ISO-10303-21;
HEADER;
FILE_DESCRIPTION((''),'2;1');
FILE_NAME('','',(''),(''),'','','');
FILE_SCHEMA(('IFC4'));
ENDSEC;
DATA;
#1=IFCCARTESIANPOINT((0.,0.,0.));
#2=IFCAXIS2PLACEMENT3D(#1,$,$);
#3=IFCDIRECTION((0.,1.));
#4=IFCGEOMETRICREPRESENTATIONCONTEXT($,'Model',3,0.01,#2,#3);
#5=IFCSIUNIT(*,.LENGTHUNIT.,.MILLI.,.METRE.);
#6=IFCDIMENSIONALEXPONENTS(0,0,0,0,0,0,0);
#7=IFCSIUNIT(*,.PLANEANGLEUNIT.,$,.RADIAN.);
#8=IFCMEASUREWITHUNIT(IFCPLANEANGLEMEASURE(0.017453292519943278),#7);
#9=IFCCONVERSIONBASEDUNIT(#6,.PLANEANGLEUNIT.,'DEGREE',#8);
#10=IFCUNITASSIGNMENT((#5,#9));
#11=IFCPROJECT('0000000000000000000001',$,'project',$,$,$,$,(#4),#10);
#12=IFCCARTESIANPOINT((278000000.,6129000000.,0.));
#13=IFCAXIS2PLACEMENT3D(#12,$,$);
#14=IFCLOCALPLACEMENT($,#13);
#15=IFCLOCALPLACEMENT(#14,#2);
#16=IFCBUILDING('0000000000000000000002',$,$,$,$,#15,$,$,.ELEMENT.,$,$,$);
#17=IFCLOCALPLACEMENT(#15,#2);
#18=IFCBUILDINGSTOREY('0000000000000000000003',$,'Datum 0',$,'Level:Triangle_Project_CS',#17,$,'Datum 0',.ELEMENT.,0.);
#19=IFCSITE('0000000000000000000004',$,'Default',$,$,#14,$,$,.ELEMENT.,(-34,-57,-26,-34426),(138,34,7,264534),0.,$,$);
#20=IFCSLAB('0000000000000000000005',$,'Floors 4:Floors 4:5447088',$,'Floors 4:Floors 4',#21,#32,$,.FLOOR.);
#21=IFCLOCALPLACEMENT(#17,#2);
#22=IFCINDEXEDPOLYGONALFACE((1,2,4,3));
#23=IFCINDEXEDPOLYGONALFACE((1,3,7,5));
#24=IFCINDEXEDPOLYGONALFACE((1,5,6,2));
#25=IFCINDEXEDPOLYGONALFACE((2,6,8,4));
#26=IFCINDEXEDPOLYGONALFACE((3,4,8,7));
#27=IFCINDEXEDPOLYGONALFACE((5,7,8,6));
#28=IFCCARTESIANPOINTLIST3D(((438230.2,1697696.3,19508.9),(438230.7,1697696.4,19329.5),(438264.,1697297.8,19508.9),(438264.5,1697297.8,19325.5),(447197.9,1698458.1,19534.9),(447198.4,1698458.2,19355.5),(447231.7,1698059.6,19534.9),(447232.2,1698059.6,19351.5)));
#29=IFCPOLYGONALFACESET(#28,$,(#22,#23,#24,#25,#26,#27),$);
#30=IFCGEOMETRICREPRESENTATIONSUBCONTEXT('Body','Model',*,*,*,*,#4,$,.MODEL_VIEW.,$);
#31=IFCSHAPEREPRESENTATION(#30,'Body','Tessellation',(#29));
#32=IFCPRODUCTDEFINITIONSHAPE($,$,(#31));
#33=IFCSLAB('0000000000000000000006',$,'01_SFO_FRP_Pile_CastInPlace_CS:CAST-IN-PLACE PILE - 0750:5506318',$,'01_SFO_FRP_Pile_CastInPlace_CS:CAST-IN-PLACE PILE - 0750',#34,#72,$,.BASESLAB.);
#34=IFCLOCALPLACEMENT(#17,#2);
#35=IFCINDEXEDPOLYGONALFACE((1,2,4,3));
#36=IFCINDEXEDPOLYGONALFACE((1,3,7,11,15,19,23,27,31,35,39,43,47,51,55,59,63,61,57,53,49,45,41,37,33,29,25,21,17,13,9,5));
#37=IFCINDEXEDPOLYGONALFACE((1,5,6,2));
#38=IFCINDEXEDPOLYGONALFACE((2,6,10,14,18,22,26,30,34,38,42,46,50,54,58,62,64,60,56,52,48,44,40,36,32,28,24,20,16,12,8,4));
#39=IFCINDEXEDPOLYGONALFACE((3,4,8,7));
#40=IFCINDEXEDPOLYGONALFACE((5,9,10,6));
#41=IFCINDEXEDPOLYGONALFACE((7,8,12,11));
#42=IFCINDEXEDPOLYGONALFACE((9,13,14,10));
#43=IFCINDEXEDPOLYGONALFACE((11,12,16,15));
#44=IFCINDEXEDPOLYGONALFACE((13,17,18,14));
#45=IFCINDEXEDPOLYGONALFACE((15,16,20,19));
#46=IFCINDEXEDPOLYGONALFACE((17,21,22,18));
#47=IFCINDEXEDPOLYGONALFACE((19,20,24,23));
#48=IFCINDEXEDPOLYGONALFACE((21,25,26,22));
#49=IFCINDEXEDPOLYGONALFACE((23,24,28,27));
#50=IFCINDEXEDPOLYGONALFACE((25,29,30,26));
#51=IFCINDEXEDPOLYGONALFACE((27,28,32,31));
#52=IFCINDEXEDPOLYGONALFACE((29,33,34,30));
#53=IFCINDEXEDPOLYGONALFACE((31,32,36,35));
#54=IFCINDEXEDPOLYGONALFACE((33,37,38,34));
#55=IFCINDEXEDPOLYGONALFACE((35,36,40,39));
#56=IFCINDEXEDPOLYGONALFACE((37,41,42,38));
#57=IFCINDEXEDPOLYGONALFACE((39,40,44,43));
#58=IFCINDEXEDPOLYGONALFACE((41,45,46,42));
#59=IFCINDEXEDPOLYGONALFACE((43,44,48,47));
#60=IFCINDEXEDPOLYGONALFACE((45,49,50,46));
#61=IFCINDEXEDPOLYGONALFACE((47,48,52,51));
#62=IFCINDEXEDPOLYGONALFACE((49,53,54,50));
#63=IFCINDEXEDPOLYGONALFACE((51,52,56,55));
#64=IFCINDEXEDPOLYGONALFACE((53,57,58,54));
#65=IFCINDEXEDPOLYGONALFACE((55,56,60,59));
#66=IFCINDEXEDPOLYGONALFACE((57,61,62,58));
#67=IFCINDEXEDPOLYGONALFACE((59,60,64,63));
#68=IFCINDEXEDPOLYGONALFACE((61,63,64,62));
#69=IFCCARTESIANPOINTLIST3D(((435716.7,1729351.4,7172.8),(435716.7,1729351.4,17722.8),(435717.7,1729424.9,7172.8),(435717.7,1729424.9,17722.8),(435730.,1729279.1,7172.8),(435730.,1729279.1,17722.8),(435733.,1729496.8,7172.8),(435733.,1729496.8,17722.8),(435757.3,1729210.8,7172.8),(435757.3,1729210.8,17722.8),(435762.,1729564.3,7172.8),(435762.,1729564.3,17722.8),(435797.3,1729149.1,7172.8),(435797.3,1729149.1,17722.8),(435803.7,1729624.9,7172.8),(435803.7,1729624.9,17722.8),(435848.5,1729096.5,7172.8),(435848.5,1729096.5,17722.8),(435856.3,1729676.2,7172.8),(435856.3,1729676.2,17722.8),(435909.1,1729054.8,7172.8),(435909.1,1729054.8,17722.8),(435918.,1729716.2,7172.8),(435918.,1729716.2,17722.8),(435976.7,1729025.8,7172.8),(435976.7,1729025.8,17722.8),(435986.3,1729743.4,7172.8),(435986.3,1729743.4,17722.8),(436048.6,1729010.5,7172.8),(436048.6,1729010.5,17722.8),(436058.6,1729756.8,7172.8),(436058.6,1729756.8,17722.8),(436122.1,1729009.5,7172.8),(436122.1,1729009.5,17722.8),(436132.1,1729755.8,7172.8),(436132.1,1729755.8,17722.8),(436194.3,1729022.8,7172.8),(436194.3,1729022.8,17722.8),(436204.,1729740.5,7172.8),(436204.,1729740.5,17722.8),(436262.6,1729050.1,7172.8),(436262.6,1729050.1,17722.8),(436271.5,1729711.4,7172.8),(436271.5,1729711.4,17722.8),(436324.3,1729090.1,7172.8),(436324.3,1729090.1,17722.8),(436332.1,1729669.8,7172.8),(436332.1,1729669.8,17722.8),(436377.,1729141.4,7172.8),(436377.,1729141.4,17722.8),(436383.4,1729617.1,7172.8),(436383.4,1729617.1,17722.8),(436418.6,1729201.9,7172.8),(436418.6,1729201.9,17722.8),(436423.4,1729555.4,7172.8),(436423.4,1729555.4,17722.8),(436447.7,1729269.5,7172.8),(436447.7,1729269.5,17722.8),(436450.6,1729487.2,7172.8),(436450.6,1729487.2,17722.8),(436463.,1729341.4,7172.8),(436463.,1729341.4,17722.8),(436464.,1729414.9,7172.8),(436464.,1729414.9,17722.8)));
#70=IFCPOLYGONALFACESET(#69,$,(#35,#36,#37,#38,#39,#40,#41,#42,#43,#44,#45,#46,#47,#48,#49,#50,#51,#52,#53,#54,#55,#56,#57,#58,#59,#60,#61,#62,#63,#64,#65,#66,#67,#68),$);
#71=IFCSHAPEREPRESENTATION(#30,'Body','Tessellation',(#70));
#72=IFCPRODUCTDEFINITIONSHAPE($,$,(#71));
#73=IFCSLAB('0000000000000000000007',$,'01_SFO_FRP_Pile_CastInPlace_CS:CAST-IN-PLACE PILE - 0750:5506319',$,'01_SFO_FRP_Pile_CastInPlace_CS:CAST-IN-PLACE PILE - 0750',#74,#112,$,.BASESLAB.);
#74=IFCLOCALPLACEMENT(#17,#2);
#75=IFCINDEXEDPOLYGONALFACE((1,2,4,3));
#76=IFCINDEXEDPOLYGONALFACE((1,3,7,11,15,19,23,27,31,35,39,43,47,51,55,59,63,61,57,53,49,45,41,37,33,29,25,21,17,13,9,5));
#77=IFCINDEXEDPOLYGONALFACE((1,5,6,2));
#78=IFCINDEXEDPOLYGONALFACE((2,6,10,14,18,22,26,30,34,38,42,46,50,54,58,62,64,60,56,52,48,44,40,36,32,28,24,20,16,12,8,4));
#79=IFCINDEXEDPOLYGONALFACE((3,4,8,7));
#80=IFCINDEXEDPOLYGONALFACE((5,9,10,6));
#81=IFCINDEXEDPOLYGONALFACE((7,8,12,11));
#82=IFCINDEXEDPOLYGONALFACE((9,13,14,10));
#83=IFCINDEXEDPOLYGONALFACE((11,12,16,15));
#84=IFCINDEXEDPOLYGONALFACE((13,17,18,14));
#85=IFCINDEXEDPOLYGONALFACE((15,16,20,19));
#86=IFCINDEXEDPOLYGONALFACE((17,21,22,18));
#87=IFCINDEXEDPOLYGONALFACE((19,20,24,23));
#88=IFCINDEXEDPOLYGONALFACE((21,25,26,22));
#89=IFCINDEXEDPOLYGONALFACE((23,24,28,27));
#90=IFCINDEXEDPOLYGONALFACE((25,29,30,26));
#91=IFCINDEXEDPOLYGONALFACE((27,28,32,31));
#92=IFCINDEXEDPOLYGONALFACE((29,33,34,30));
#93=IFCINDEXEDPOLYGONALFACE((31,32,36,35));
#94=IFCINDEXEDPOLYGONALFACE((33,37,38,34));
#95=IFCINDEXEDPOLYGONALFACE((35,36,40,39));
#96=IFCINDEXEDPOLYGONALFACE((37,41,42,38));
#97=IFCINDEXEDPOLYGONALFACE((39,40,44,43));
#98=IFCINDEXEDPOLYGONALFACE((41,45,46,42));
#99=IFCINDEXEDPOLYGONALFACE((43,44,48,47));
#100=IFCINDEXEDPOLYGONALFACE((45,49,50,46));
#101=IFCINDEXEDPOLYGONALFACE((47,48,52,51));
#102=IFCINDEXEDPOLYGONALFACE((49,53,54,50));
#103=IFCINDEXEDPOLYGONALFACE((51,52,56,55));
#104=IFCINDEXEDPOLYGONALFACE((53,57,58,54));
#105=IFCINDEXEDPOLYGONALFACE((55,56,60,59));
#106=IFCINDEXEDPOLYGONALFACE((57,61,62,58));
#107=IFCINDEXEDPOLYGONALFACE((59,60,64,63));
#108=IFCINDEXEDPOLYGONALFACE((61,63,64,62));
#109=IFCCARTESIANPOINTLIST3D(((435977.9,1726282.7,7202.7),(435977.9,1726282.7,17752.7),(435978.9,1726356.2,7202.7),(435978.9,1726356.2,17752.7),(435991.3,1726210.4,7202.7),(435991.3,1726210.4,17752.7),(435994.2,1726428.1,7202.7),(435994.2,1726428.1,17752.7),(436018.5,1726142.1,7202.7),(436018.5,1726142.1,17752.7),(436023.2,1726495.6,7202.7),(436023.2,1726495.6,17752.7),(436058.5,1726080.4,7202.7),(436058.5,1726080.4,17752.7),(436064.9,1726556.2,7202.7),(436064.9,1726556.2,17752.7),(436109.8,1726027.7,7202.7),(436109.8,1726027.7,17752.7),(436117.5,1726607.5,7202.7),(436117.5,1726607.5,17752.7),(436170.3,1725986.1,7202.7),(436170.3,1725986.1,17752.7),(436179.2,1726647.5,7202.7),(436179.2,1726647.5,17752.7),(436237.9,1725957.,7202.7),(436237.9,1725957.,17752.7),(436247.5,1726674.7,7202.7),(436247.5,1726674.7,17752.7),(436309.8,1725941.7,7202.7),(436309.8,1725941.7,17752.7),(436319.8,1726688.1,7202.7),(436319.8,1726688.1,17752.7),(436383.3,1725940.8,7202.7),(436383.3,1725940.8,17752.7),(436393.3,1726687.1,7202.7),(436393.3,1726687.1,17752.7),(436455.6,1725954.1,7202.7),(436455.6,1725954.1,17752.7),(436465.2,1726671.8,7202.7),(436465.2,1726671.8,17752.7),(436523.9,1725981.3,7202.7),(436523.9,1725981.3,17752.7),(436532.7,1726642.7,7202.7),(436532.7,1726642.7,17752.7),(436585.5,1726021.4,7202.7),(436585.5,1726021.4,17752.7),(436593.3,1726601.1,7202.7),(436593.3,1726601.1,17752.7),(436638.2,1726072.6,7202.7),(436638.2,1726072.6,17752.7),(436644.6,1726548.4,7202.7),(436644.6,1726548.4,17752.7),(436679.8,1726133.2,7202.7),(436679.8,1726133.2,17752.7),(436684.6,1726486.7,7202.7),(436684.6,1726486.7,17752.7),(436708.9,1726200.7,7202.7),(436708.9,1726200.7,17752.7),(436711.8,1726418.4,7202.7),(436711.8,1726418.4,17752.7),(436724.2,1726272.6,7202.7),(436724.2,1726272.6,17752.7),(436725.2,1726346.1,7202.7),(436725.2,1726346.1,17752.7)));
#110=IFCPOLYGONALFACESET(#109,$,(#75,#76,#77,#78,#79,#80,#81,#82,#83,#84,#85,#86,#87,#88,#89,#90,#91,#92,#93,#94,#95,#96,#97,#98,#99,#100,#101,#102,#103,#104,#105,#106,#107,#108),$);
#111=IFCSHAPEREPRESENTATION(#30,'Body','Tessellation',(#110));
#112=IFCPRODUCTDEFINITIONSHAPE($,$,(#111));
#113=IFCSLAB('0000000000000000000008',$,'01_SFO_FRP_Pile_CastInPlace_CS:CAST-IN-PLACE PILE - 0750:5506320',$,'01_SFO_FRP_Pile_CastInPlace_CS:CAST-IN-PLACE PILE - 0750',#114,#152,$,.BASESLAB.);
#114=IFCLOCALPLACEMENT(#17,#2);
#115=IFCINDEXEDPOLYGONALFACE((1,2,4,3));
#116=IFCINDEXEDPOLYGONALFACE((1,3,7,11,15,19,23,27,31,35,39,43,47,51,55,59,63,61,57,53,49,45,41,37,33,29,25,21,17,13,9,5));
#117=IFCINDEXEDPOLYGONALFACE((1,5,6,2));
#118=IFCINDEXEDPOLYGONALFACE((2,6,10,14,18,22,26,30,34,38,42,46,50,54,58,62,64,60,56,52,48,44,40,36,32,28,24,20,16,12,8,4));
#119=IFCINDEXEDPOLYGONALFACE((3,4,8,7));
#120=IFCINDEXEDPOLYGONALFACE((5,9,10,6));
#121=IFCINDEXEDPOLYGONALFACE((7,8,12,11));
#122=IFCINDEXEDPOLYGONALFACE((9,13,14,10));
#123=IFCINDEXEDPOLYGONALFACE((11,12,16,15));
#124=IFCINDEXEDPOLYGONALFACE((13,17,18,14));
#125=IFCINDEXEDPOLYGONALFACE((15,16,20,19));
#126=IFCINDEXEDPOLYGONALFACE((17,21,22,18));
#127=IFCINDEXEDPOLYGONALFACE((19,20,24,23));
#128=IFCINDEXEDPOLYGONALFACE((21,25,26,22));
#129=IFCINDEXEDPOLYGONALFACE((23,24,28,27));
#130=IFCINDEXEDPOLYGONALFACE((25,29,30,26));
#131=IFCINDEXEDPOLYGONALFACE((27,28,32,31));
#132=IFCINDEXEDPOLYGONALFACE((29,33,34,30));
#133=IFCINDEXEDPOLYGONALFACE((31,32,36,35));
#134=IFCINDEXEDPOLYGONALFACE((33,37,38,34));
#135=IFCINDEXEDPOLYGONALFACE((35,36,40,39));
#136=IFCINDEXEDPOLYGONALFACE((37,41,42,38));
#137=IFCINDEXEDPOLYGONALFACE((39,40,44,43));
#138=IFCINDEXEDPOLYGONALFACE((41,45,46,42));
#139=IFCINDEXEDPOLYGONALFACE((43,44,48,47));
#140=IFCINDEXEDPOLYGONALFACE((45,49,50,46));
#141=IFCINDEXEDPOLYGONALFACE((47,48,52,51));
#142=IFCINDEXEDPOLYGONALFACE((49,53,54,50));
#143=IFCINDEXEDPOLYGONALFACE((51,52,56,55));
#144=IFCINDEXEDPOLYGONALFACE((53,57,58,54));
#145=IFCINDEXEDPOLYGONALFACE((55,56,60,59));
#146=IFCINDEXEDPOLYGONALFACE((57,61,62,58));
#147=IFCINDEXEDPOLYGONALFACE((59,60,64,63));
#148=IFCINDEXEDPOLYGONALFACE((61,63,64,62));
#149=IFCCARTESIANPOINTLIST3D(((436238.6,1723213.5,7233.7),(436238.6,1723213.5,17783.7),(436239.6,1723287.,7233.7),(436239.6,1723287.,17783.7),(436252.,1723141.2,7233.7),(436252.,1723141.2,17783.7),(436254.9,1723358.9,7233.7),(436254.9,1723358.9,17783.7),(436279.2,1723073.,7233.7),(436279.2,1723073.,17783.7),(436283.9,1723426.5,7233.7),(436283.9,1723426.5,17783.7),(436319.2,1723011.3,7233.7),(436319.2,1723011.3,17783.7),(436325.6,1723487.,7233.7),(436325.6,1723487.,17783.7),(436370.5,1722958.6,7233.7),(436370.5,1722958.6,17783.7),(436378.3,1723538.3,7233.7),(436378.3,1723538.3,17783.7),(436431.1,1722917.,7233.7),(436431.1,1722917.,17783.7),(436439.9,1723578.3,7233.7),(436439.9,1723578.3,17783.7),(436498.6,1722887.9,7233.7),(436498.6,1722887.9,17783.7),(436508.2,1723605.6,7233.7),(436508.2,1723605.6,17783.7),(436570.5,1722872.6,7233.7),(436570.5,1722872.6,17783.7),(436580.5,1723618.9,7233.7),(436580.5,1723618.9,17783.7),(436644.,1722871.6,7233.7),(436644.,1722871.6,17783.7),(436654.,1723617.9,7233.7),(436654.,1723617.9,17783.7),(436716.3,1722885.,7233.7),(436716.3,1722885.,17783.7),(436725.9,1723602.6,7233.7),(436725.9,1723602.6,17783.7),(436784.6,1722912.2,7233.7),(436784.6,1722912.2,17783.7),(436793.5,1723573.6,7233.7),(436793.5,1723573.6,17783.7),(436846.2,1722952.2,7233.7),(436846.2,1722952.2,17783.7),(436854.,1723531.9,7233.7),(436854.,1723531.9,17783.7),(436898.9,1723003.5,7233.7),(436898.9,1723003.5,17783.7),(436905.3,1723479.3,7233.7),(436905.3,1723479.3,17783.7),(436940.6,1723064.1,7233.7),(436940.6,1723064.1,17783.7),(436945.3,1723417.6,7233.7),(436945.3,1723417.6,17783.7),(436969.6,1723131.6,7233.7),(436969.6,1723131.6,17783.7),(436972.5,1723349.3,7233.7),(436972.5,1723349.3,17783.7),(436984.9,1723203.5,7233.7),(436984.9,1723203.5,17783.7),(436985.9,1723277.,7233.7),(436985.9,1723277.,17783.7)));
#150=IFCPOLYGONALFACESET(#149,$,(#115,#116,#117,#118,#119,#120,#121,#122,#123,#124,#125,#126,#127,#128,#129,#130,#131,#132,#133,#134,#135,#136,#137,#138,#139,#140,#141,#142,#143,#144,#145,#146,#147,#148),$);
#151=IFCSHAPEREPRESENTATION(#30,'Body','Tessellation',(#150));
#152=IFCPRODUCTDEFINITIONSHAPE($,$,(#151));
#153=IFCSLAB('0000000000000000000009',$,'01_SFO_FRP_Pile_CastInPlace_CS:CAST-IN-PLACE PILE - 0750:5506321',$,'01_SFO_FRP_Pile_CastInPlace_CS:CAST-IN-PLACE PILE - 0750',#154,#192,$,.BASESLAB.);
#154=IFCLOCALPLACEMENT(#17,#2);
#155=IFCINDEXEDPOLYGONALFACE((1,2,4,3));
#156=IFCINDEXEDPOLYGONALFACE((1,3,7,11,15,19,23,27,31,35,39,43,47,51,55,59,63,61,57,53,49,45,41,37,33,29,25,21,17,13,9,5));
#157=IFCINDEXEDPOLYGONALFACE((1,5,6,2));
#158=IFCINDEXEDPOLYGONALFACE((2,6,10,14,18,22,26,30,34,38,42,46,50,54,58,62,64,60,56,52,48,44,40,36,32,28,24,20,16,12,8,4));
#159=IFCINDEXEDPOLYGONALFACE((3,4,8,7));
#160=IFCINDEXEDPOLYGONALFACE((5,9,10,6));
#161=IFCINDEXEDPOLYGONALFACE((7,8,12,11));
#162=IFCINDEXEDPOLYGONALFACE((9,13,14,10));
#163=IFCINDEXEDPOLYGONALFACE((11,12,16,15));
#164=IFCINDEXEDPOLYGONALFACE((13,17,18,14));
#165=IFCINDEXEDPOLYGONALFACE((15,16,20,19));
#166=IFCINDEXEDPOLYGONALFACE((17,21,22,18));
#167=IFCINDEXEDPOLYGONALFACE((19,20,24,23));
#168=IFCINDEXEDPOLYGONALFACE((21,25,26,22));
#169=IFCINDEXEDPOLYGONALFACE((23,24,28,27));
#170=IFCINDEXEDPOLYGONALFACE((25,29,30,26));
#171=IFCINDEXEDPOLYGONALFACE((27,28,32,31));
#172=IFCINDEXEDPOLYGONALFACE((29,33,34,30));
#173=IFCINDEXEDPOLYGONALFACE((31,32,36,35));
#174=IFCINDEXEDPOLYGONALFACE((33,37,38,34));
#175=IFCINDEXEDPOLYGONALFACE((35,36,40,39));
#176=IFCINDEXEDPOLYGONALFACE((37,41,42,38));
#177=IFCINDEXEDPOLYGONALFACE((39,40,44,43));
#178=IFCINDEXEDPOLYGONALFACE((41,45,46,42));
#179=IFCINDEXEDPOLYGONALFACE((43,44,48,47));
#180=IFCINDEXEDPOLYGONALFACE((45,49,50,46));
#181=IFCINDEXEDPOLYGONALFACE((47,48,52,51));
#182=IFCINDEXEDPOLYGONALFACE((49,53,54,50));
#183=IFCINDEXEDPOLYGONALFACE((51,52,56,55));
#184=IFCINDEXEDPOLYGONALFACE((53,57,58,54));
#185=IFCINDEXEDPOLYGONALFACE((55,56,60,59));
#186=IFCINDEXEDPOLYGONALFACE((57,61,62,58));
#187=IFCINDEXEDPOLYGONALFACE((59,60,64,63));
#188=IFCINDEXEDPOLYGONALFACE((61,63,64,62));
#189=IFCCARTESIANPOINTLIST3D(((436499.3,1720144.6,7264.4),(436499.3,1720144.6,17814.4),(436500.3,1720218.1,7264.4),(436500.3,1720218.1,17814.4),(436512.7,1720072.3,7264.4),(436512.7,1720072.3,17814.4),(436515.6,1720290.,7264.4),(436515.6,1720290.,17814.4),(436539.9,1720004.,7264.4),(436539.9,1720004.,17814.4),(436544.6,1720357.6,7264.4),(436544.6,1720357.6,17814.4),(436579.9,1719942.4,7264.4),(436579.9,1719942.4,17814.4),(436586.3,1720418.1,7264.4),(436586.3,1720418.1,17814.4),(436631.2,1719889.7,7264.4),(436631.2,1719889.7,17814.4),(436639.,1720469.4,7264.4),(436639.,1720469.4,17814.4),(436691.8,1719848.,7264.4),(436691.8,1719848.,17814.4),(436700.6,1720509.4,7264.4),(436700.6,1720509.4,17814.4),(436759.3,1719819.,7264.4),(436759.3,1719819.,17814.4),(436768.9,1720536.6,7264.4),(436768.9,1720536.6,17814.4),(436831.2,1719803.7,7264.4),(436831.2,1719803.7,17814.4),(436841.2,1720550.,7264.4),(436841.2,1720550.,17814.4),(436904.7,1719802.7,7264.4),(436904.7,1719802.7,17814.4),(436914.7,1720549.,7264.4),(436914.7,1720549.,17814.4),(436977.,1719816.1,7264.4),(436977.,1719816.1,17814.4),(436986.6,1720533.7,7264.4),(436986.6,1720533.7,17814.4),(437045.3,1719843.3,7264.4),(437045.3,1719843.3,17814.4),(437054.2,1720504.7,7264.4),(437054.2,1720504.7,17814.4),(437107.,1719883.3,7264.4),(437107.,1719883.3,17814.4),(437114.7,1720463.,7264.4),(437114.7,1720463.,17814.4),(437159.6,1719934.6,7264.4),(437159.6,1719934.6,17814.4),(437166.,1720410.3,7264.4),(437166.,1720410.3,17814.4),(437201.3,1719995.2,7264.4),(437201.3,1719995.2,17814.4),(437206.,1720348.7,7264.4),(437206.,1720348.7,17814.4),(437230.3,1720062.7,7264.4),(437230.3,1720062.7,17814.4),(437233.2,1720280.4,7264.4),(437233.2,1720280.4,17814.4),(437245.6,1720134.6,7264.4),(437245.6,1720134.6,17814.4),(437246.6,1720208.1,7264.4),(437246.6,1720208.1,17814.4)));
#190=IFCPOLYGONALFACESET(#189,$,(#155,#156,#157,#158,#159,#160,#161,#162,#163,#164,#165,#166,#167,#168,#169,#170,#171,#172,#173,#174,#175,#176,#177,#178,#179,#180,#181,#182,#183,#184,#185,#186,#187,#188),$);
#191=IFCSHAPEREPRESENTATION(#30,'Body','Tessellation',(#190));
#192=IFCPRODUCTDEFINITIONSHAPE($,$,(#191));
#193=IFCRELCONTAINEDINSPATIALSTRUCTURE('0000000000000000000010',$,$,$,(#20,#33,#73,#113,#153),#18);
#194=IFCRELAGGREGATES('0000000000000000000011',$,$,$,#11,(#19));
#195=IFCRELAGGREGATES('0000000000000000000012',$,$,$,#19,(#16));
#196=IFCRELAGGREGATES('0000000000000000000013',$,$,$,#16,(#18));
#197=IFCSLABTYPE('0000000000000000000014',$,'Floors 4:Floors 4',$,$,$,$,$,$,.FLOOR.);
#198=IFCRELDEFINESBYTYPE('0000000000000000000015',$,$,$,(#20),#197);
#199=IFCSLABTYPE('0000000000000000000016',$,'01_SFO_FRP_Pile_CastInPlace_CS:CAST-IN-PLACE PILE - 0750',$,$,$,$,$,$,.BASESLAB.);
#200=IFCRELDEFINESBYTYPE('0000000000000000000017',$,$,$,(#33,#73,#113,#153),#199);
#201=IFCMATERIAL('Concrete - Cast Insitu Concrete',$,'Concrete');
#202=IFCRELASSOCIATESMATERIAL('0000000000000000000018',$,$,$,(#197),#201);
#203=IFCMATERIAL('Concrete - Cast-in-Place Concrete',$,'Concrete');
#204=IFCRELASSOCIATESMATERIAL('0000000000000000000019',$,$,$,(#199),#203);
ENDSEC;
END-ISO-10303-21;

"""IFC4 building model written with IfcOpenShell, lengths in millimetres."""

from ifc_helpers import new_model, entity, si_unit, converted_unit, direction, frame, origin, place, context, subcontext, project, spatial, arc, indexed_curve, outline, extrude, material, type_object, element, save


model = new_model("IFC4")

# Units and contexts
model_context = context("Model", 3, precision=0.01, world=origin(), true_north=direction((0.0, 1.0)))
body_context = subcontext(model_context, "Body", "Model", "MODEL_VIEW")
ifc_project = project(units=[si_unit("LENGTHUNIT", "METRE", prefix="MILLI"), converted_unit("PLANEANGLEUNIT", "DEGREE", entity("IfcPlaneAngleMeasure", 0.017453292519943278), si_unit("PLANEANGLEUNIT", "RADIAN"), dimensions=[0, 0, 0, 0, 0, 0, 0])], contexts=[model_context])

# Site, building, storey
site_placement = place(None, frame((278000000.0, 6129000000.0, 0.0)))
site = spatial("IfcSite", under=ifc_project, at=site_placement, Name="Default", CompositionType="ELEMENT", RefLatitude=(-34, -57, -26, -34426), RefLongitude=(138, 34, 7, 264534), RefElevation=0.0)
building_placement = place(site_placement, origin())
building = spatial("IfcBuilding", under=site, at=building_placement, CompositionType="ELEMENT")
storey_placement = place(building_placement, frame((0.0, 0.0, 0.0)))
storey = spatial("IfcBuildingStorey", under=building, at=storey_placement, Name="Datum 0", ObjectType="Level:Triangle_Project_CS", LongName="Datum 0", CompositionType="ELEMENT", Elevation=0.0)

# Shared definitions
ifc_material_1 = material(Name="Concrete - Cast-in-Place Concrete", Category="Concrete")

# Slabs
ifc_material_2 = material(Name="Concrete - Cast Insitu Concrete", Category="Concrete")
slab_type_1 = type_object("IfcSlabType", Name="Floors 4:Floors 4", PredefinedType="FLOOR", material=ifc_material_2)
slab_1_placement = place(storey_placement, origin())
element("IfcSlab", 1, at=slab_1_placement, inside=storey, type_object=slab_type_1, Name="Floors 4:Floors 4:5447088", ObjectType="Floors 4:Floors 4", PredefinedType="FLOOR", context=body_context, shape_type="SweptSolid", body=[
    extrude(outline(indexed_curve([(-200.9, -90.7), (199.1, -90.7), (200.9, 88.7), (-199.1, 92.7), (-200.9, -90.7)], self_intersect=False)), frame((438247.3, 1697497.1, 19418.2), z_axis=(0.996407, 0.084646, 0.002889), x_axis=(-0.084671, 0.996358, 0.010058)), (0.0, 0.0, 1.0), 9000.0),
])
slab_type_2 = type_object("IfcSlabType", Name="01_SFO_FRP_Pile_CastInPlace_CS:CAST-IN-PLACE PILE - 0750", PredefinedType="BASESLAB", material=ifc_material_1)
slab_2_placement = place(storey_placement, origin())
element("IfcSlab", 2, at=slab_2_placement, inside=storey, type_object=slab_type_2, Name="01_SFO_FRP_Pile_CastInPlace_CS:CAST-IN-PLACE PILE - 0750:5506318", ObjectType="01_SFO_FRP_Pile_CastInPlace_CS:CAST-IN-PLACE PILE - 0750", PredefinedType="BASESLAB", context=body_context, shape_type="SweptSolid", body=[
    extrude(outline(indexed_curve([(-375.0, 0.0), (0.0, -375.0), (375.0, 0.0), (0.0, 375.0)], segments=[arc(1, 2, 3), arc(3, 4, 1)], self_intersect=False)), frame((436090.3, 1729383.1, 7172.8), z_axis=(0.0, 0.0, 1.0), x_axis=(-0.996411, -0.084646, 0.0)), (0.0, 0.0, 1.0), 10550.0),
])
slab_3_placement = place(storey_placement, origin())
element("IfcSlab", 3, at=slab_3_placement, inside=storey, type_object=slab_type_2, Name="01_SFO_FRP_Pile_CastInPlace_CS:CAST-IN-PLACE PILE - 0750:5506319", ObjectType="01_SFO_FRP_Pile_CastInPlace_CS:CAST-IN-PLACE PILE - 0750", PredefinedType="BASESLAB", context=body_context, shape_type="SweptSolid", body=[
    extrude(outline(indexed_curve([(-375.0, 0.0), (0.0, -375.0), (375.0, 0.0), (0.0, 375.0)], segments=[arc(1, 2, 3), arc(3, 4, 1)], self_intersect=False)), frame((436351.5, 1726314.4, 7202.7), z_axis=(0.0, 0.0, 1.0), x_axis=(-0.996411, -0.084646, 0.0)), (0.0, 0.0, 1.0), 10550.0),
])
slab_4_placement = place(storey_placement, origin())
element("IfcSlab", 4, at=slab_4_placement, inside=storey, type_object=slab_type_2, Name="01_SFO_FRP_Pile_CastInPlace_CS:CAST-IN-PLACE PILE - 0750:5506320", ObjectType="01_SFO_FRP_Pile_CastInPlace_CS:CAST-IN-PLACE PILE - 0750", PredefinedType="BASESLAB", context=body_context, shape_type="SweptSolid", body=[
    extrude(outline(indexed_curve([(-375.0, 0.0), (0.0, -375.0), (375.0, 0.0), (0.0, 375.0)], segments=[arc(1, 2, 3), arc(3, 4, 1)], self_intersect=False)), frame((436612.3, 1723245.3, 7233.7), z_axis=(0.0, 0.0, 1.0), x_axis=(-0.996411, -0.084646, 0.0)), (0.0, 0.0, 1.0), 10550.0),
])
slab_5_placement = place(storey_placement, origin())
element("IfcSlab", 5, at=slab_5_placement, inside=storey, type_object=slab_type_2, Name="01_SFO_FRP_Pile_CastInPlace_CS:CAST-IN-PLACE PILE - 0750:5506321", ObjectType="01_SFO_FRP_Pile_CastInPlace_CS:CAST-IN-PLACE PILE - 0750", PredefinedType="BASESLAB", context=body_context, shape_type="SweptSolid", body=[
    extrude(outline(indexed_curve([(-375.0, 0.0), (0.0, -375.0), (375.0, 0.0), (0.0, 375.0)], segments=[arc(1, 2, 3), arc(3, 4, 1)], self_intersect=False)), frame((436873.0, 1720176.4, 7264.4), z_axis=(0.0, 0.0, 1.0), x_axis=(-0.996411, -0.084646, 0.0)), (0.0, 0.0, 1.0), 10550.0),
])

save(model, "model.ifc")
